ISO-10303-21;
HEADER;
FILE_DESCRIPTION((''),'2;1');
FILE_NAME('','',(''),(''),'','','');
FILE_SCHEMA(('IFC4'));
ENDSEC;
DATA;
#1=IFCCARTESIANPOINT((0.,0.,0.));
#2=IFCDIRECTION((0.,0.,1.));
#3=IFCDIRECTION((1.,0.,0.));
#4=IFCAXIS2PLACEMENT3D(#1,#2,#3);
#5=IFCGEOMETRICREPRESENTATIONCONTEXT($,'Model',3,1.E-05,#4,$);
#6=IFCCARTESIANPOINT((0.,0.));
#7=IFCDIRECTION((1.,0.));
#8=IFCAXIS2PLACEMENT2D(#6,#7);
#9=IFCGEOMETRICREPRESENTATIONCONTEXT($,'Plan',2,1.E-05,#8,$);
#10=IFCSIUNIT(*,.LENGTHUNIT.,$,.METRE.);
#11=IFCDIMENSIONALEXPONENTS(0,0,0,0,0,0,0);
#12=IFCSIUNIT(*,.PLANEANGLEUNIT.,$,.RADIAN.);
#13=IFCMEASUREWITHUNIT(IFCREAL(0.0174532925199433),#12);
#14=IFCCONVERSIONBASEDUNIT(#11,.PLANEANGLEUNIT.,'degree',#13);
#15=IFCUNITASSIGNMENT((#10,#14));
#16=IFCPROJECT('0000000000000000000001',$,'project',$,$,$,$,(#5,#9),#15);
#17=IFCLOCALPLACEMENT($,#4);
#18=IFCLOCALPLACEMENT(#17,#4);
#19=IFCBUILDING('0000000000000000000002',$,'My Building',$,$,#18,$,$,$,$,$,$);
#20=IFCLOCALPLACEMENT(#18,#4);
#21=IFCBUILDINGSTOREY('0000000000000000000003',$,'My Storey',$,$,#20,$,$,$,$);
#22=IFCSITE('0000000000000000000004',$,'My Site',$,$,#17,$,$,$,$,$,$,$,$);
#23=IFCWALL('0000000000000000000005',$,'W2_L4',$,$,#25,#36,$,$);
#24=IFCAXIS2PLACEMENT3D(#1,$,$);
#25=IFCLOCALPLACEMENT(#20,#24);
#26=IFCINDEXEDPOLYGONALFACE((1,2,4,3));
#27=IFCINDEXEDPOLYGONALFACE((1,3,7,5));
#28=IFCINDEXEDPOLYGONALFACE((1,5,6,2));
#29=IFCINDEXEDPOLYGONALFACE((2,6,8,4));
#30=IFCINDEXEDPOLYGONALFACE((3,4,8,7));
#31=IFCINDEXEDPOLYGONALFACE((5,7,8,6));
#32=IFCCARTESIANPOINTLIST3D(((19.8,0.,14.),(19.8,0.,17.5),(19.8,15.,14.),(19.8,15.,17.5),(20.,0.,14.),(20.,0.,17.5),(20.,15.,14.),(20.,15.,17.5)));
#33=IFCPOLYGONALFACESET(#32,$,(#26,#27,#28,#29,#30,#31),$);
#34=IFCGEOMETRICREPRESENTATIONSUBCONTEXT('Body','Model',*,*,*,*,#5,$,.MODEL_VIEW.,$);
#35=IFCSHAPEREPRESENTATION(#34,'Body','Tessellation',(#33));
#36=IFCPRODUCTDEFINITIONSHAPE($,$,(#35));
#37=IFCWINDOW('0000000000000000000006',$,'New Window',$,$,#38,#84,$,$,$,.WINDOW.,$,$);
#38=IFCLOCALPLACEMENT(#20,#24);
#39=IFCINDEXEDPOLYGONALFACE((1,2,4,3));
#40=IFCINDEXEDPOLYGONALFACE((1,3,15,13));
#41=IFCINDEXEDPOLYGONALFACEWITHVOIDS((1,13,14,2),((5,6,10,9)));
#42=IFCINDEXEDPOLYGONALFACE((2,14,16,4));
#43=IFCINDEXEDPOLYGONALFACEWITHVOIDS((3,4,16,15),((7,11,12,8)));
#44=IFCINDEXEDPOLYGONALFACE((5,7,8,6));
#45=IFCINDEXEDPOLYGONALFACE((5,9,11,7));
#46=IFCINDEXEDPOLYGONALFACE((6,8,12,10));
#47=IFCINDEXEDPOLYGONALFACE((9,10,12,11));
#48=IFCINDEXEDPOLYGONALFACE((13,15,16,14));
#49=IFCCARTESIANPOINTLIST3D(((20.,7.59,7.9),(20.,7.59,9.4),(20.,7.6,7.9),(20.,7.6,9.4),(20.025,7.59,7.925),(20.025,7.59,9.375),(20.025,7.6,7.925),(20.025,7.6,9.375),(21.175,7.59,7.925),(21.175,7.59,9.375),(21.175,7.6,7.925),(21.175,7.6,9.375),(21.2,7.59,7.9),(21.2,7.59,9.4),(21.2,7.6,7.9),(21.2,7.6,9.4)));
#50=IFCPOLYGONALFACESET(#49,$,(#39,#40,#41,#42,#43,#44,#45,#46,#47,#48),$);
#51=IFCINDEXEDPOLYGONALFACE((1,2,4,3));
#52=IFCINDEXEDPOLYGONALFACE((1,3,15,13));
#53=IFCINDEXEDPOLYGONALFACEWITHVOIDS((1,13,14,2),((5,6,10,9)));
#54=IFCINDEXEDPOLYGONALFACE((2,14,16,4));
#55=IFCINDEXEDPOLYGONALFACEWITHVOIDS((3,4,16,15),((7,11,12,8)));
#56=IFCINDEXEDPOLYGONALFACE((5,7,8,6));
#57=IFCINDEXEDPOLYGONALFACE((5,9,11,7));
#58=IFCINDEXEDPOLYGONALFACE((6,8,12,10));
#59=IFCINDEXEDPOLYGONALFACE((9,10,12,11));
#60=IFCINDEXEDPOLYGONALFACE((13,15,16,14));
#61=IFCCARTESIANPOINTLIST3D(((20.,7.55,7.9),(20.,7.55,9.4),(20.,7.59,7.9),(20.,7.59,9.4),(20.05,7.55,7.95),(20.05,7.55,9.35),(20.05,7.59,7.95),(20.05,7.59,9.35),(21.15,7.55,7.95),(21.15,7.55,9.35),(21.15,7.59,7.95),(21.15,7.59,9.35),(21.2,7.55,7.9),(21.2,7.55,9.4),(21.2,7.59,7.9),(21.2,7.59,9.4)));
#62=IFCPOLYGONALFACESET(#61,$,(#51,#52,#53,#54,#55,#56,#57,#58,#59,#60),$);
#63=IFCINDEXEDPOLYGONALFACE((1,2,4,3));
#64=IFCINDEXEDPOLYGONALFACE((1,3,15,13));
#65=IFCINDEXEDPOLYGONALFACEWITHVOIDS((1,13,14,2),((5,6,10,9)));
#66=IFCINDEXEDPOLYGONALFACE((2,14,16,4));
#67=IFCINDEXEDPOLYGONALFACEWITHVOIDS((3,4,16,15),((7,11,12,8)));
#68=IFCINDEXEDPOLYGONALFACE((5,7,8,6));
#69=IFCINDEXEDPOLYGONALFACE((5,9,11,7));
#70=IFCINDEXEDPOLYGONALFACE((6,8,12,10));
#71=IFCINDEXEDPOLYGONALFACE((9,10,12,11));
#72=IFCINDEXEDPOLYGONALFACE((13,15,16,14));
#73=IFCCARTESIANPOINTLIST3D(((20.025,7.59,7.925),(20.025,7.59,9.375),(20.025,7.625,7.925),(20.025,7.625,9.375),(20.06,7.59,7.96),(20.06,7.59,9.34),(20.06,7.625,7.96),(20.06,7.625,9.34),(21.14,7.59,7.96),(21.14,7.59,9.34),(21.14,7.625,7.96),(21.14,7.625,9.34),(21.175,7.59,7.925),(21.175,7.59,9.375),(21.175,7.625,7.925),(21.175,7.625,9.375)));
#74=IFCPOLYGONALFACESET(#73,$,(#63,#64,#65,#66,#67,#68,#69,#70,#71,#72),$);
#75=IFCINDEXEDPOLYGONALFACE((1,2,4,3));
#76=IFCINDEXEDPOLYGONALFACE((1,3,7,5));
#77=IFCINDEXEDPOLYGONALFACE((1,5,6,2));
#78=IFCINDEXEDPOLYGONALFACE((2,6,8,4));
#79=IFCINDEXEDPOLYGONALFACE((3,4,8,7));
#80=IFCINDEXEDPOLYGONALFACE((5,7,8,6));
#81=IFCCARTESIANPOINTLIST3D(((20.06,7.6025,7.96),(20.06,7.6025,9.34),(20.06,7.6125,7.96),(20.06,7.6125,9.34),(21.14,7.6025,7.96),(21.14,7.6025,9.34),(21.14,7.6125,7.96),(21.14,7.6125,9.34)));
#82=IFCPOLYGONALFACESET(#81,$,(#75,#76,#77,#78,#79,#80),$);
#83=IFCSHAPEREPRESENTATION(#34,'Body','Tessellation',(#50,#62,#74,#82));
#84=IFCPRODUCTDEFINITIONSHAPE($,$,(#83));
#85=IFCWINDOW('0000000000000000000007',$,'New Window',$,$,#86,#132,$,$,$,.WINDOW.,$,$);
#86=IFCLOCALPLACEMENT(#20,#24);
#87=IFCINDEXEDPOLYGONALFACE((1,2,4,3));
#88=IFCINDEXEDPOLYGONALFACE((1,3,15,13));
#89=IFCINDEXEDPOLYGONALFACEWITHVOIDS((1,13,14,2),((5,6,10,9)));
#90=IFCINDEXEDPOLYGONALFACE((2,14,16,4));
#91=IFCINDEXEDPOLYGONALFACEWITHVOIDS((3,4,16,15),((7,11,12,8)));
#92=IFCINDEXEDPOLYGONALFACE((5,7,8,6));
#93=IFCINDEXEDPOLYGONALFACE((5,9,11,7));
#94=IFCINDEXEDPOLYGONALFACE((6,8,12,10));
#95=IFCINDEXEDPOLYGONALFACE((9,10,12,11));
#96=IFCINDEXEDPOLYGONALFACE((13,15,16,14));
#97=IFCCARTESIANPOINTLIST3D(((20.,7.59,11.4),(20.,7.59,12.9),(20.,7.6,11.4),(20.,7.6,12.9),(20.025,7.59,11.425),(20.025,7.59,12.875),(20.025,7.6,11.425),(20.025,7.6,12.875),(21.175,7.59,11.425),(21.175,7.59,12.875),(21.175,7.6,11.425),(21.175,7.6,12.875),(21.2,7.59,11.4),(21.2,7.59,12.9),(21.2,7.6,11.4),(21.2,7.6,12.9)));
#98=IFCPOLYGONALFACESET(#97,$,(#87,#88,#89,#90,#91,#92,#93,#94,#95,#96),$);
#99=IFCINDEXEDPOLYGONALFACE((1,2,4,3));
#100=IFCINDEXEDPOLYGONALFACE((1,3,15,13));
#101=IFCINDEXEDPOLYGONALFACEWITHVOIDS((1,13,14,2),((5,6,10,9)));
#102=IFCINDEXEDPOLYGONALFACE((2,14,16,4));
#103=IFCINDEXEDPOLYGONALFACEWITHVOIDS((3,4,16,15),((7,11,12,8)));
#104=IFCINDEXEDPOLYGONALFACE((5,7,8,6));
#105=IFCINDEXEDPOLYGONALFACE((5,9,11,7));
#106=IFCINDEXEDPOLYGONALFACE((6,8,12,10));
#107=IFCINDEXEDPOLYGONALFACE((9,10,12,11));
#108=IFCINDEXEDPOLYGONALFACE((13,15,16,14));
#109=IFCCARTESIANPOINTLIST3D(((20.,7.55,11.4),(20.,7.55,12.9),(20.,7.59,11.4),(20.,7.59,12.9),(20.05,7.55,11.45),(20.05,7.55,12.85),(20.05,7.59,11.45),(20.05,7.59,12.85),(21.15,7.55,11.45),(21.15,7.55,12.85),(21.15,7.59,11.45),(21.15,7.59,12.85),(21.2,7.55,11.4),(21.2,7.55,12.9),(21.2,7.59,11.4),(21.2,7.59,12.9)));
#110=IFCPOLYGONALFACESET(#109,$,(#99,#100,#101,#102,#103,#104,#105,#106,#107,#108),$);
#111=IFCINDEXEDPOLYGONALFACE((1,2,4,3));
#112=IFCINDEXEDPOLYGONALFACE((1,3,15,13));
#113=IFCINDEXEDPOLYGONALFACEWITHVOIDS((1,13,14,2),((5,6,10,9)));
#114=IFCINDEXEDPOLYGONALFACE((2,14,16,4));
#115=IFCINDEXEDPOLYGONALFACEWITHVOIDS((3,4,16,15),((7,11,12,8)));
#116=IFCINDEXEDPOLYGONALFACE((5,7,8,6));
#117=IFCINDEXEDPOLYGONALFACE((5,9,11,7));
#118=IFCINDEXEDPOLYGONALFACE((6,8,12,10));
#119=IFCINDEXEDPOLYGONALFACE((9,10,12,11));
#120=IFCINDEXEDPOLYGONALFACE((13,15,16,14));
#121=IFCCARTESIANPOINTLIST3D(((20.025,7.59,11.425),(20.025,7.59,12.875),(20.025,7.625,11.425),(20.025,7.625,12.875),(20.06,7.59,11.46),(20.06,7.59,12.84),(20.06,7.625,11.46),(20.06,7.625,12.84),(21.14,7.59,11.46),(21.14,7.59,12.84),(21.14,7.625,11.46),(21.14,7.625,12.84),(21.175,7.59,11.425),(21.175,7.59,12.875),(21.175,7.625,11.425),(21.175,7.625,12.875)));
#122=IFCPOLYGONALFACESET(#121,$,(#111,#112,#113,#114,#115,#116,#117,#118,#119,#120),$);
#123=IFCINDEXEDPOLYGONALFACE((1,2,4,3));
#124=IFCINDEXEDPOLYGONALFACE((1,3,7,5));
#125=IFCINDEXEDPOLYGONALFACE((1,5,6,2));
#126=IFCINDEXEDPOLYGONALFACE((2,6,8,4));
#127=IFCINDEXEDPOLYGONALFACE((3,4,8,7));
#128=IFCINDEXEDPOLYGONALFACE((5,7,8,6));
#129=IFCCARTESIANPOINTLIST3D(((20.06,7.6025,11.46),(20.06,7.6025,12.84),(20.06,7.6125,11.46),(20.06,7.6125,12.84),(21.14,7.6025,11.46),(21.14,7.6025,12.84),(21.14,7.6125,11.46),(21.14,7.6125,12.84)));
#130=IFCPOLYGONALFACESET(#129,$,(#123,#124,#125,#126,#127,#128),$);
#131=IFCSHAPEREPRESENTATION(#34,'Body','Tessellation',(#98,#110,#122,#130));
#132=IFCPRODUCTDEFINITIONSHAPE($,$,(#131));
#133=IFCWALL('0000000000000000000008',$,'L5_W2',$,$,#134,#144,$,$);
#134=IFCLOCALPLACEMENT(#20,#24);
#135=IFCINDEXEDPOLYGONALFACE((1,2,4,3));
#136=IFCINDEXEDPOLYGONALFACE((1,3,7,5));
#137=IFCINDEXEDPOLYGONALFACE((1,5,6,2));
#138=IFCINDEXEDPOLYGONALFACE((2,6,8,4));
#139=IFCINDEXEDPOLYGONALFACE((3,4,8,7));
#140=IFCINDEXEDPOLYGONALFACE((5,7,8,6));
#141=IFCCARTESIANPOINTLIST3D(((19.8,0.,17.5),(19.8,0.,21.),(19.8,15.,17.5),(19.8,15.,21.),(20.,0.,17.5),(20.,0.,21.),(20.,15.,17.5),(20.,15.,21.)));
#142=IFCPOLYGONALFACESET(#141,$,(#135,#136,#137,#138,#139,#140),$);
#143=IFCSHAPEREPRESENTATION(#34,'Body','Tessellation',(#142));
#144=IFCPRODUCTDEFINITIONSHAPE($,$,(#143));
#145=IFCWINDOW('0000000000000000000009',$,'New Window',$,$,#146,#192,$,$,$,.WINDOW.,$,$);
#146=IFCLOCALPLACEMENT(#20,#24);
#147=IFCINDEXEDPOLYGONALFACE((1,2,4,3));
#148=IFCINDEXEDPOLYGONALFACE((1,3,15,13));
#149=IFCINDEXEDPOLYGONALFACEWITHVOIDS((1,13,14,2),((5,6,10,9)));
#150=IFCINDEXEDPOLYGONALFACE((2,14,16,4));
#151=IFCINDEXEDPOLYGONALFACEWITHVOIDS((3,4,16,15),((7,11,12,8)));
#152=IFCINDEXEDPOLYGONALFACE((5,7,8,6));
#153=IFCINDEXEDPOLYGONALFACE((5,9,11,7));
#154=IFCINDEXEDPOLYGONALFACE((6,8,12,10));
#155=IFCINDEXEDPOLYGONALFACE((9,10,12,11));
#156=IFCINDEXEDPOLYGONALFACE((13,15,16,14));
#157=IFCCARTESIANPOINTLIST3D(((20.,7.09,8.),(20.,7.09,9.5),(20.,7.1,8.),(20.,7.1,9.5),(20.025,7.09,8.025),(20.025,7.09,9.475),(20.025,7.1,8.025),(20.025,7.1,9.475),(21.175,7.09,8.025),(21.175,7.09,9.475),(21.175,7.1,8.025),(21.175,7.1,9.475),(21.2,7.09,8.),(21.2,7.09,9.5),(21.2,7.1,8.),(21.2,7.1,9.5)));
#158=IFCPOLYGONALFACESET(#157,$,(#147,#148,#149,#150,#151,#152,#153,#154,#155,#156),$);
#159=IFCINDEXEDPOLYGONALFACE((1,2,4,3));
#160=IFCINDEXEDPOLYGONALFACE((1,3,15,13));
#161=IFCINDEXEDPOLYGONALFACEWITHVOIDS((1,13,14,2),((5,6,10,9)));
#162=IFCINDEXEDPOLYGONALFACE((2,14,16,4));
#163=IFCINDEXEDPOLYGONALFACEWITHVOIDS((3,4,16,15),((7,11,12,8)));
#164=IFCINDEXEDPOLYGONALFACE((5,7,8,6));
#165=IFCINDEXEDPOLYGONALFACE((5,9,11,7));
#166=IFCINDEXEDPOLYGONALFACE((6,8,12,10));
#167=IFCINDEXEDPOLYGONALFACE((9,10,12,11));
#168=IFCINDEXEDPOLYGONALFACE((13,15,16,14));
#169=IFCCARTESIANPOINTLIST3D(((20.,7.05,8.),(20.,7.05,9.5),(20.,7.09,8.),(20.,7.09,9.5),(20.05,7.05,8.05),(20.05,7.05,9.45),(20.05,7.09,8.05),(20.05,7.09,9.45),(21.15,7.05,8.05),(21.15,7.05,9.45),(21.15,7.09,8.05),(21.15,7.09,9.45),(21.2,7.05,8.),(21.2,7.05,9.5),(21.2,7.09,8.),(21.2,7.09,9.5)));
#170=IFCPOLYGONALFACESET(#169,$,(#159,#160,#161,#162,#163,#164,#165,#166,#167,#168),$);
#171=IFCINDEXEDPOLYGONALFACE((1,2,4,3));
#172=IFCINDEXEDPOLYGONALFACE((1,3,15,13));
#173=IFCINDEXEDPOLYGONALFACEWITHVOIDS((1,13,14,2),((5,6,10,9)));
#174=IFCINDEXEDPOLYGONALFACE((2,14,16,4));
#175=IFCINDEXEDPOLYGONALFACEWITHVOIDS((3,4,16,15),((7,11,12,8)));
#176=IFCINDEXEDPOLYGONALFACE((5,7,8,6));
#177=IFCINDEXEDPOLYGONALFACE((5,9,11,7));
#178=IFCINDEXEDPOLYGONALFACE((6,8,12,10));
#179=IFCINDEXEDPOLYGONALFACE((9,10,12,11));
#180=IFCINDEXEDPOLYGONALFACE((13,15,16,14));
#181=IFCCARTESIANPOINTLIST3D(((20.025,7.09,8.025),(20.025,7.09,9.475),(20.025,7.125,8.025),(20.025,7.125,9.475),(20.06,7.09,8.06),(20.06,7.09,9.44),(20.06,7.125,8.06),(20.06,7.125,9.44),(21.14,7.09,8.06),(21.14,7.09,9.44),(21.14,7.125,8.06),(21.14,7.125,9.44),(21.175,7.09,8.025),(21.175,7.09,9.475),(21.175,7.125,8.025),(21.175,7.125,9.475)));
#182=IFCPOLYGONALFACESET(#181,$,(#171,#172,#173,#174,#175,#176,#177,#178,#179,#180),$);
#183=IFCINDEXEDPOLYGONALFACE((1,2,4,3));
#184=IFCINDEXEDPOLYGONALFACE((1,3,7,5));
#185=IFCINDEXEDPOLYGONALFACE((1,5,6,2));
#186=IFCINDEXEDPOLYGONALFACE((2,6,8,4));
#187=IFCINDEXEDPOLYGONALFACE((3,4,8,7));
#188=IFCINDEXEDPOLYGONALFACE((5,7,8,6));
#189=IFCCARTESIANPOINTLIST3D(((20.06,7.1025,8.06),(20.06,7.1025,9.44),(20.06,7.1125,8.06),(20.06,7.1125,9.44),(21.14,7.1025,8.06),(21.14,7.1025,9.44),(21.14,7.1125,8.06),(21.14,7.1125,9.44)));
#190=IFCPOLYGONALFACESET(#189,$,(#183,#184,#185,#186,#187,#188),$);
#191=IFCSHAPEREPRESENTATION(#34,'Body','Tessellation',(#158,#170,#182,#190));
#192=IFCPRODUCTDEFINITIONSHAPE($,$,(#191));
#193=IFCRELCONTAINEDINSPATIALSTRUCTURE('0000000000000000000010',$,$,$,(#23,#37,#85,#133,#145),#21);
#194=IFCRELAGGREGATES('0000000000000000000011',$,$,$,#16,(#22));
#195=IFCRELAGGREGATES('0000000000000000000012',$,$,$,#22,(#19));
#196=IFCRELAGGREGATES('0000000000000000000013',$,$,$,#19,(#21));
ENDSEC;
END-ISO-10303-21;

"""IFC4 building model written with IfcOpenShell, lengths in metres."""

from ifc_helpers import new_model, entity, si_unit, converted_unit, frame, origin_with_axes, origin_2d_with_axis, place, context, subcontext, project, spatial, line, indexed_curve, outline, extrude, element, save


model = new_model("IFC4")

# Units and contexts
model_context = context("Model", 3, precision=1e-05, world=origin_with_axes())
plan_context = context("Plan", 2, precision=1e-05, world=origin_2d_with_axis())
body_context = subcontext(model_context, "Body", "Model", "MODEL_VIEW")
ifc_project = project(units=[si_unit("LENGTHUNIT", "METRE"), converted_unit("PLANEANGLEUNIT", "degree", entity("IfcReal", 0.0174532925199433), si_unit("PLANEANGLEUNIT", "RADIAN"), dimensions=[0, 0, 0, 0, 0, 0, 0])], contexts=[model_context, plan_context])

# Site, building, storey
site_placement = place(None, origin_with_axes())
site = spatial("IfcSite", under=ifc_project, at=site_placement, Name="My Site")
building_placement = place(site_placement, origin_with_axes())
building = spatial("IfcBuilding", under=site, at=building_placement, Name="My Building")
storey_placement = place(building_placement, origin_with_axes())
storey = spatial("IfcBuildingStorey", under=building, at=storey_placement, Name="My Storey")

# Wall
wall_1_placement = place(storey_placement, frame((20.0, 0.0, 14.0), z_axis=(0.0, 0.0, 1.0), x_axis=(0.0, 1.0, 0.0)))
element("IfcWall", 1, at=wall_1_placement, inside=storey, Name="W2_L4", context=body_context, shape_type="SweptSolid", body=[
    extrude(outline(indexed_curve([(0.0, 0.0), (0.0, 0.2), (15.0, 0.2), (15.0, 0.0), (0.0, 0.0)], self_intersect=False)), origin_with_axes(), (0.0, 0.0, 1.0), 3.5),
])

# Windows
for number, where, z_axis, x_axis, name in (
    (2, (20.0, 7.5, 7.9), (0.0, 0.0, 1.0), (1.0, 0.0, 0.0), "New Window"),
    (3, (20.0, 7.5, 11.4), (0.0, 0.0, 1.0), (1.0, 0.0, 0.0), "New Window"),
):
    element("IfcWindow", number, at=place(storey_placement, frame(where, z_axis=z_axis, x_axis=x_axis)), inside=storey, Name=name, PredefinedType="WINDOW", context=body_context, shape_type="SweptSolid", body=[
        extrude(outline(indexed_curve([(0.0, 0.0), (1.2, 0.0), (1.2, 1.5), (0.0, 1.5)], segments=[line(1, 2, 3, 4, 1)]), holes=[indexed_curve([(0.025, 0.025), (1.175, 0.025), (1.175, 1.475), (0.025, 1.475)], segments=[line(1, 2, 3, 4, 1)])]), frame((0.0, 0.09, 0.0), z_axis=(0.0, -1.0, 0.0), x_axis=(1.0, 0.0, 0.0)), (0.0, 0.0, -1.0), 0.01),
        extrude(outline(indexed_curve([(0.0, 0.0), (1.2, 0.0), (1.2, 1.5), (0.0, 1.5)], segments=[line(1, 2, 3, 4, 1)]), holes=[indexed_curve([(0.05, 0.05), (1.15, 0.05), (1.15, 1.45), (0.05, 1.45)], segments=[line(1, 2, 3, 4, 1)])]), frame((0.0, 0.05, 0.0), z_axis=(0.0, -1.0, 0.0), x_axis=(1.0, 0.0, 0.0)), (0.0, 0.0, -1.0), 0.04),
        extrude(outline(indexed_curve([(0.0, 0.0), (1.15, 0.0), (1.15, 1.45), (0.0, 1.45)], segments=[line(1, 2, 3, 4, 1)]), holes=[indexed_curve([(0.035, 0.035), (1.115, 0.035), (1.115, 1.415), (0.035, 1.415)], segments=[line(1, 2, 3, 4, 1)])]), frame((0.025, 0.09, 0.025), z_axis=(0.0, -1.0, 0.0), x_axis=(1.0, 0.0, 0.0)), (0.0, 0.0, -1.0), 0.035),
        extrude(outline(indexed_curve([(0.035, 0.035), (1.115, 0.035), (1.115, 1.415), (0.035, 1.415)], segments=[line(1, 2, 3, 4, 1)])), frame((0.025, 0.1025, 0.025), z_axis=(0.0, -1.0, 0.0), x_axis=(1.0, 0.0, 0.0)), (0.0, 0.0, -1.0), 0.01),
    ])

# Wall
for number, where, z_axis, x_axis, name in (
    (4, (20.0, 0.0, 17.5), (0.0, 0.0, 1.0), (0.0, 1.0, 0.0), "L5_W2"),
):
    element("IfcWall", number, at=place(storey_placement, frame(where, z_axis=z_axis, x_axis=x_axis)), inside=storey, Name=name, context=body_context, shape_type="SweptSolid", body=[
        extrude(outline(indexed_curve([(0.0, 0.0), (0.0, 0.2), (15.0, 0.2), (15.0, 0.0), (0.0, 0.0)], self_intersect=False)), origin_with_axes(), (0.0, 0.0, 1.0), 3.5),
    ])

# Window
for number, where, z_axis, x_axis, name in (
    (5, (20.0, 7.0, 8.0), (0.0, 0.0, 1.0), (1.0, 0.0, 0.0), "New Window"),
):
    element("IfcWindow", number, at=place(storey_placement, frame(where, z_axis=z_axis, x_axis=x_axis)), inside=storey, Name=name, PredefinedType="WINDOW", context=body_context, shape_type="SweptSolid", body=[
        extrude(outline(indexed_curve([(0.0, 0.0), (1.2, 0.0), (1.2, 1.5), (0.0, 1.5)], segments=[line(1, 2, 3, 4, 1)]), holes=[indexed_curve([(0.025, 0.025), (1.175, 0.025), (1.175, 1.475), (0.025, 1.475)], segments=[line(1, 2, 3, 4, 1)])]), frame((0.0, 0.09, 0.0), z_axis=(0.0, -1.0, 0.0), x_axis=(1.0, 0.0, 0.0)), (0.0, 0.0, -1.0), 0.01),
        extrude(outline(indexed_curve([(0.0, 0.0), (1.2, 0.0), (1.2, 1.5), (0.0, 1.5)], segments=[line(1, 2, 3, 4, 1)]), holes=[indexed_curve([(0.05, 0.05), (1.15, 0.05), (1.15, 1.45), (0.05, 1.45)], segments=[line(1, 2, 3, 4, 1)])]), frame((0.0, 0.05, 0.0), z_axis=(0.0, -1.0, 0.0), x_axis=(1.0, 0.0, 0.0)), (0.0, 0.0, -1.0), 0.04),
        extrude(outline(indexed_curve([(0.0, 0.0), (1.15, 0.0), (1.15, 1.45), (0.0, 1.45)], segments=[line(1, 2, 3, 4, 1)]), holes=[indexed_curve([(0.035, 0.035), (1.115, 0.035), (1.115, 1.415), (0.035, 1.415)], segments=[line(1, 2, 3, 4, 1)])]), frame((0.025, 0.09, 0.025), z_axis=(0.0, -1.0, 0.0), x_axis=(1.0, 0.0, 0.0)), (0.0, 0.0, -1.0), 0.035),
        extrude(outline(indexed_curve([(0.035, 0.035), (1.115, 0.035), (1.115, 1.415), (0.035, 1.415)], segments=[line(1, 2, 3, 4, 1)])), frame((0.025, 0.1025, 0.025), z_axis=(0.0, -1.0, 0.0), x_axis=(1.0, 0.0, 0.0)), (0.0, 0.0, -1.0), 0.01),
    ])

save(model, "model.ifc")
